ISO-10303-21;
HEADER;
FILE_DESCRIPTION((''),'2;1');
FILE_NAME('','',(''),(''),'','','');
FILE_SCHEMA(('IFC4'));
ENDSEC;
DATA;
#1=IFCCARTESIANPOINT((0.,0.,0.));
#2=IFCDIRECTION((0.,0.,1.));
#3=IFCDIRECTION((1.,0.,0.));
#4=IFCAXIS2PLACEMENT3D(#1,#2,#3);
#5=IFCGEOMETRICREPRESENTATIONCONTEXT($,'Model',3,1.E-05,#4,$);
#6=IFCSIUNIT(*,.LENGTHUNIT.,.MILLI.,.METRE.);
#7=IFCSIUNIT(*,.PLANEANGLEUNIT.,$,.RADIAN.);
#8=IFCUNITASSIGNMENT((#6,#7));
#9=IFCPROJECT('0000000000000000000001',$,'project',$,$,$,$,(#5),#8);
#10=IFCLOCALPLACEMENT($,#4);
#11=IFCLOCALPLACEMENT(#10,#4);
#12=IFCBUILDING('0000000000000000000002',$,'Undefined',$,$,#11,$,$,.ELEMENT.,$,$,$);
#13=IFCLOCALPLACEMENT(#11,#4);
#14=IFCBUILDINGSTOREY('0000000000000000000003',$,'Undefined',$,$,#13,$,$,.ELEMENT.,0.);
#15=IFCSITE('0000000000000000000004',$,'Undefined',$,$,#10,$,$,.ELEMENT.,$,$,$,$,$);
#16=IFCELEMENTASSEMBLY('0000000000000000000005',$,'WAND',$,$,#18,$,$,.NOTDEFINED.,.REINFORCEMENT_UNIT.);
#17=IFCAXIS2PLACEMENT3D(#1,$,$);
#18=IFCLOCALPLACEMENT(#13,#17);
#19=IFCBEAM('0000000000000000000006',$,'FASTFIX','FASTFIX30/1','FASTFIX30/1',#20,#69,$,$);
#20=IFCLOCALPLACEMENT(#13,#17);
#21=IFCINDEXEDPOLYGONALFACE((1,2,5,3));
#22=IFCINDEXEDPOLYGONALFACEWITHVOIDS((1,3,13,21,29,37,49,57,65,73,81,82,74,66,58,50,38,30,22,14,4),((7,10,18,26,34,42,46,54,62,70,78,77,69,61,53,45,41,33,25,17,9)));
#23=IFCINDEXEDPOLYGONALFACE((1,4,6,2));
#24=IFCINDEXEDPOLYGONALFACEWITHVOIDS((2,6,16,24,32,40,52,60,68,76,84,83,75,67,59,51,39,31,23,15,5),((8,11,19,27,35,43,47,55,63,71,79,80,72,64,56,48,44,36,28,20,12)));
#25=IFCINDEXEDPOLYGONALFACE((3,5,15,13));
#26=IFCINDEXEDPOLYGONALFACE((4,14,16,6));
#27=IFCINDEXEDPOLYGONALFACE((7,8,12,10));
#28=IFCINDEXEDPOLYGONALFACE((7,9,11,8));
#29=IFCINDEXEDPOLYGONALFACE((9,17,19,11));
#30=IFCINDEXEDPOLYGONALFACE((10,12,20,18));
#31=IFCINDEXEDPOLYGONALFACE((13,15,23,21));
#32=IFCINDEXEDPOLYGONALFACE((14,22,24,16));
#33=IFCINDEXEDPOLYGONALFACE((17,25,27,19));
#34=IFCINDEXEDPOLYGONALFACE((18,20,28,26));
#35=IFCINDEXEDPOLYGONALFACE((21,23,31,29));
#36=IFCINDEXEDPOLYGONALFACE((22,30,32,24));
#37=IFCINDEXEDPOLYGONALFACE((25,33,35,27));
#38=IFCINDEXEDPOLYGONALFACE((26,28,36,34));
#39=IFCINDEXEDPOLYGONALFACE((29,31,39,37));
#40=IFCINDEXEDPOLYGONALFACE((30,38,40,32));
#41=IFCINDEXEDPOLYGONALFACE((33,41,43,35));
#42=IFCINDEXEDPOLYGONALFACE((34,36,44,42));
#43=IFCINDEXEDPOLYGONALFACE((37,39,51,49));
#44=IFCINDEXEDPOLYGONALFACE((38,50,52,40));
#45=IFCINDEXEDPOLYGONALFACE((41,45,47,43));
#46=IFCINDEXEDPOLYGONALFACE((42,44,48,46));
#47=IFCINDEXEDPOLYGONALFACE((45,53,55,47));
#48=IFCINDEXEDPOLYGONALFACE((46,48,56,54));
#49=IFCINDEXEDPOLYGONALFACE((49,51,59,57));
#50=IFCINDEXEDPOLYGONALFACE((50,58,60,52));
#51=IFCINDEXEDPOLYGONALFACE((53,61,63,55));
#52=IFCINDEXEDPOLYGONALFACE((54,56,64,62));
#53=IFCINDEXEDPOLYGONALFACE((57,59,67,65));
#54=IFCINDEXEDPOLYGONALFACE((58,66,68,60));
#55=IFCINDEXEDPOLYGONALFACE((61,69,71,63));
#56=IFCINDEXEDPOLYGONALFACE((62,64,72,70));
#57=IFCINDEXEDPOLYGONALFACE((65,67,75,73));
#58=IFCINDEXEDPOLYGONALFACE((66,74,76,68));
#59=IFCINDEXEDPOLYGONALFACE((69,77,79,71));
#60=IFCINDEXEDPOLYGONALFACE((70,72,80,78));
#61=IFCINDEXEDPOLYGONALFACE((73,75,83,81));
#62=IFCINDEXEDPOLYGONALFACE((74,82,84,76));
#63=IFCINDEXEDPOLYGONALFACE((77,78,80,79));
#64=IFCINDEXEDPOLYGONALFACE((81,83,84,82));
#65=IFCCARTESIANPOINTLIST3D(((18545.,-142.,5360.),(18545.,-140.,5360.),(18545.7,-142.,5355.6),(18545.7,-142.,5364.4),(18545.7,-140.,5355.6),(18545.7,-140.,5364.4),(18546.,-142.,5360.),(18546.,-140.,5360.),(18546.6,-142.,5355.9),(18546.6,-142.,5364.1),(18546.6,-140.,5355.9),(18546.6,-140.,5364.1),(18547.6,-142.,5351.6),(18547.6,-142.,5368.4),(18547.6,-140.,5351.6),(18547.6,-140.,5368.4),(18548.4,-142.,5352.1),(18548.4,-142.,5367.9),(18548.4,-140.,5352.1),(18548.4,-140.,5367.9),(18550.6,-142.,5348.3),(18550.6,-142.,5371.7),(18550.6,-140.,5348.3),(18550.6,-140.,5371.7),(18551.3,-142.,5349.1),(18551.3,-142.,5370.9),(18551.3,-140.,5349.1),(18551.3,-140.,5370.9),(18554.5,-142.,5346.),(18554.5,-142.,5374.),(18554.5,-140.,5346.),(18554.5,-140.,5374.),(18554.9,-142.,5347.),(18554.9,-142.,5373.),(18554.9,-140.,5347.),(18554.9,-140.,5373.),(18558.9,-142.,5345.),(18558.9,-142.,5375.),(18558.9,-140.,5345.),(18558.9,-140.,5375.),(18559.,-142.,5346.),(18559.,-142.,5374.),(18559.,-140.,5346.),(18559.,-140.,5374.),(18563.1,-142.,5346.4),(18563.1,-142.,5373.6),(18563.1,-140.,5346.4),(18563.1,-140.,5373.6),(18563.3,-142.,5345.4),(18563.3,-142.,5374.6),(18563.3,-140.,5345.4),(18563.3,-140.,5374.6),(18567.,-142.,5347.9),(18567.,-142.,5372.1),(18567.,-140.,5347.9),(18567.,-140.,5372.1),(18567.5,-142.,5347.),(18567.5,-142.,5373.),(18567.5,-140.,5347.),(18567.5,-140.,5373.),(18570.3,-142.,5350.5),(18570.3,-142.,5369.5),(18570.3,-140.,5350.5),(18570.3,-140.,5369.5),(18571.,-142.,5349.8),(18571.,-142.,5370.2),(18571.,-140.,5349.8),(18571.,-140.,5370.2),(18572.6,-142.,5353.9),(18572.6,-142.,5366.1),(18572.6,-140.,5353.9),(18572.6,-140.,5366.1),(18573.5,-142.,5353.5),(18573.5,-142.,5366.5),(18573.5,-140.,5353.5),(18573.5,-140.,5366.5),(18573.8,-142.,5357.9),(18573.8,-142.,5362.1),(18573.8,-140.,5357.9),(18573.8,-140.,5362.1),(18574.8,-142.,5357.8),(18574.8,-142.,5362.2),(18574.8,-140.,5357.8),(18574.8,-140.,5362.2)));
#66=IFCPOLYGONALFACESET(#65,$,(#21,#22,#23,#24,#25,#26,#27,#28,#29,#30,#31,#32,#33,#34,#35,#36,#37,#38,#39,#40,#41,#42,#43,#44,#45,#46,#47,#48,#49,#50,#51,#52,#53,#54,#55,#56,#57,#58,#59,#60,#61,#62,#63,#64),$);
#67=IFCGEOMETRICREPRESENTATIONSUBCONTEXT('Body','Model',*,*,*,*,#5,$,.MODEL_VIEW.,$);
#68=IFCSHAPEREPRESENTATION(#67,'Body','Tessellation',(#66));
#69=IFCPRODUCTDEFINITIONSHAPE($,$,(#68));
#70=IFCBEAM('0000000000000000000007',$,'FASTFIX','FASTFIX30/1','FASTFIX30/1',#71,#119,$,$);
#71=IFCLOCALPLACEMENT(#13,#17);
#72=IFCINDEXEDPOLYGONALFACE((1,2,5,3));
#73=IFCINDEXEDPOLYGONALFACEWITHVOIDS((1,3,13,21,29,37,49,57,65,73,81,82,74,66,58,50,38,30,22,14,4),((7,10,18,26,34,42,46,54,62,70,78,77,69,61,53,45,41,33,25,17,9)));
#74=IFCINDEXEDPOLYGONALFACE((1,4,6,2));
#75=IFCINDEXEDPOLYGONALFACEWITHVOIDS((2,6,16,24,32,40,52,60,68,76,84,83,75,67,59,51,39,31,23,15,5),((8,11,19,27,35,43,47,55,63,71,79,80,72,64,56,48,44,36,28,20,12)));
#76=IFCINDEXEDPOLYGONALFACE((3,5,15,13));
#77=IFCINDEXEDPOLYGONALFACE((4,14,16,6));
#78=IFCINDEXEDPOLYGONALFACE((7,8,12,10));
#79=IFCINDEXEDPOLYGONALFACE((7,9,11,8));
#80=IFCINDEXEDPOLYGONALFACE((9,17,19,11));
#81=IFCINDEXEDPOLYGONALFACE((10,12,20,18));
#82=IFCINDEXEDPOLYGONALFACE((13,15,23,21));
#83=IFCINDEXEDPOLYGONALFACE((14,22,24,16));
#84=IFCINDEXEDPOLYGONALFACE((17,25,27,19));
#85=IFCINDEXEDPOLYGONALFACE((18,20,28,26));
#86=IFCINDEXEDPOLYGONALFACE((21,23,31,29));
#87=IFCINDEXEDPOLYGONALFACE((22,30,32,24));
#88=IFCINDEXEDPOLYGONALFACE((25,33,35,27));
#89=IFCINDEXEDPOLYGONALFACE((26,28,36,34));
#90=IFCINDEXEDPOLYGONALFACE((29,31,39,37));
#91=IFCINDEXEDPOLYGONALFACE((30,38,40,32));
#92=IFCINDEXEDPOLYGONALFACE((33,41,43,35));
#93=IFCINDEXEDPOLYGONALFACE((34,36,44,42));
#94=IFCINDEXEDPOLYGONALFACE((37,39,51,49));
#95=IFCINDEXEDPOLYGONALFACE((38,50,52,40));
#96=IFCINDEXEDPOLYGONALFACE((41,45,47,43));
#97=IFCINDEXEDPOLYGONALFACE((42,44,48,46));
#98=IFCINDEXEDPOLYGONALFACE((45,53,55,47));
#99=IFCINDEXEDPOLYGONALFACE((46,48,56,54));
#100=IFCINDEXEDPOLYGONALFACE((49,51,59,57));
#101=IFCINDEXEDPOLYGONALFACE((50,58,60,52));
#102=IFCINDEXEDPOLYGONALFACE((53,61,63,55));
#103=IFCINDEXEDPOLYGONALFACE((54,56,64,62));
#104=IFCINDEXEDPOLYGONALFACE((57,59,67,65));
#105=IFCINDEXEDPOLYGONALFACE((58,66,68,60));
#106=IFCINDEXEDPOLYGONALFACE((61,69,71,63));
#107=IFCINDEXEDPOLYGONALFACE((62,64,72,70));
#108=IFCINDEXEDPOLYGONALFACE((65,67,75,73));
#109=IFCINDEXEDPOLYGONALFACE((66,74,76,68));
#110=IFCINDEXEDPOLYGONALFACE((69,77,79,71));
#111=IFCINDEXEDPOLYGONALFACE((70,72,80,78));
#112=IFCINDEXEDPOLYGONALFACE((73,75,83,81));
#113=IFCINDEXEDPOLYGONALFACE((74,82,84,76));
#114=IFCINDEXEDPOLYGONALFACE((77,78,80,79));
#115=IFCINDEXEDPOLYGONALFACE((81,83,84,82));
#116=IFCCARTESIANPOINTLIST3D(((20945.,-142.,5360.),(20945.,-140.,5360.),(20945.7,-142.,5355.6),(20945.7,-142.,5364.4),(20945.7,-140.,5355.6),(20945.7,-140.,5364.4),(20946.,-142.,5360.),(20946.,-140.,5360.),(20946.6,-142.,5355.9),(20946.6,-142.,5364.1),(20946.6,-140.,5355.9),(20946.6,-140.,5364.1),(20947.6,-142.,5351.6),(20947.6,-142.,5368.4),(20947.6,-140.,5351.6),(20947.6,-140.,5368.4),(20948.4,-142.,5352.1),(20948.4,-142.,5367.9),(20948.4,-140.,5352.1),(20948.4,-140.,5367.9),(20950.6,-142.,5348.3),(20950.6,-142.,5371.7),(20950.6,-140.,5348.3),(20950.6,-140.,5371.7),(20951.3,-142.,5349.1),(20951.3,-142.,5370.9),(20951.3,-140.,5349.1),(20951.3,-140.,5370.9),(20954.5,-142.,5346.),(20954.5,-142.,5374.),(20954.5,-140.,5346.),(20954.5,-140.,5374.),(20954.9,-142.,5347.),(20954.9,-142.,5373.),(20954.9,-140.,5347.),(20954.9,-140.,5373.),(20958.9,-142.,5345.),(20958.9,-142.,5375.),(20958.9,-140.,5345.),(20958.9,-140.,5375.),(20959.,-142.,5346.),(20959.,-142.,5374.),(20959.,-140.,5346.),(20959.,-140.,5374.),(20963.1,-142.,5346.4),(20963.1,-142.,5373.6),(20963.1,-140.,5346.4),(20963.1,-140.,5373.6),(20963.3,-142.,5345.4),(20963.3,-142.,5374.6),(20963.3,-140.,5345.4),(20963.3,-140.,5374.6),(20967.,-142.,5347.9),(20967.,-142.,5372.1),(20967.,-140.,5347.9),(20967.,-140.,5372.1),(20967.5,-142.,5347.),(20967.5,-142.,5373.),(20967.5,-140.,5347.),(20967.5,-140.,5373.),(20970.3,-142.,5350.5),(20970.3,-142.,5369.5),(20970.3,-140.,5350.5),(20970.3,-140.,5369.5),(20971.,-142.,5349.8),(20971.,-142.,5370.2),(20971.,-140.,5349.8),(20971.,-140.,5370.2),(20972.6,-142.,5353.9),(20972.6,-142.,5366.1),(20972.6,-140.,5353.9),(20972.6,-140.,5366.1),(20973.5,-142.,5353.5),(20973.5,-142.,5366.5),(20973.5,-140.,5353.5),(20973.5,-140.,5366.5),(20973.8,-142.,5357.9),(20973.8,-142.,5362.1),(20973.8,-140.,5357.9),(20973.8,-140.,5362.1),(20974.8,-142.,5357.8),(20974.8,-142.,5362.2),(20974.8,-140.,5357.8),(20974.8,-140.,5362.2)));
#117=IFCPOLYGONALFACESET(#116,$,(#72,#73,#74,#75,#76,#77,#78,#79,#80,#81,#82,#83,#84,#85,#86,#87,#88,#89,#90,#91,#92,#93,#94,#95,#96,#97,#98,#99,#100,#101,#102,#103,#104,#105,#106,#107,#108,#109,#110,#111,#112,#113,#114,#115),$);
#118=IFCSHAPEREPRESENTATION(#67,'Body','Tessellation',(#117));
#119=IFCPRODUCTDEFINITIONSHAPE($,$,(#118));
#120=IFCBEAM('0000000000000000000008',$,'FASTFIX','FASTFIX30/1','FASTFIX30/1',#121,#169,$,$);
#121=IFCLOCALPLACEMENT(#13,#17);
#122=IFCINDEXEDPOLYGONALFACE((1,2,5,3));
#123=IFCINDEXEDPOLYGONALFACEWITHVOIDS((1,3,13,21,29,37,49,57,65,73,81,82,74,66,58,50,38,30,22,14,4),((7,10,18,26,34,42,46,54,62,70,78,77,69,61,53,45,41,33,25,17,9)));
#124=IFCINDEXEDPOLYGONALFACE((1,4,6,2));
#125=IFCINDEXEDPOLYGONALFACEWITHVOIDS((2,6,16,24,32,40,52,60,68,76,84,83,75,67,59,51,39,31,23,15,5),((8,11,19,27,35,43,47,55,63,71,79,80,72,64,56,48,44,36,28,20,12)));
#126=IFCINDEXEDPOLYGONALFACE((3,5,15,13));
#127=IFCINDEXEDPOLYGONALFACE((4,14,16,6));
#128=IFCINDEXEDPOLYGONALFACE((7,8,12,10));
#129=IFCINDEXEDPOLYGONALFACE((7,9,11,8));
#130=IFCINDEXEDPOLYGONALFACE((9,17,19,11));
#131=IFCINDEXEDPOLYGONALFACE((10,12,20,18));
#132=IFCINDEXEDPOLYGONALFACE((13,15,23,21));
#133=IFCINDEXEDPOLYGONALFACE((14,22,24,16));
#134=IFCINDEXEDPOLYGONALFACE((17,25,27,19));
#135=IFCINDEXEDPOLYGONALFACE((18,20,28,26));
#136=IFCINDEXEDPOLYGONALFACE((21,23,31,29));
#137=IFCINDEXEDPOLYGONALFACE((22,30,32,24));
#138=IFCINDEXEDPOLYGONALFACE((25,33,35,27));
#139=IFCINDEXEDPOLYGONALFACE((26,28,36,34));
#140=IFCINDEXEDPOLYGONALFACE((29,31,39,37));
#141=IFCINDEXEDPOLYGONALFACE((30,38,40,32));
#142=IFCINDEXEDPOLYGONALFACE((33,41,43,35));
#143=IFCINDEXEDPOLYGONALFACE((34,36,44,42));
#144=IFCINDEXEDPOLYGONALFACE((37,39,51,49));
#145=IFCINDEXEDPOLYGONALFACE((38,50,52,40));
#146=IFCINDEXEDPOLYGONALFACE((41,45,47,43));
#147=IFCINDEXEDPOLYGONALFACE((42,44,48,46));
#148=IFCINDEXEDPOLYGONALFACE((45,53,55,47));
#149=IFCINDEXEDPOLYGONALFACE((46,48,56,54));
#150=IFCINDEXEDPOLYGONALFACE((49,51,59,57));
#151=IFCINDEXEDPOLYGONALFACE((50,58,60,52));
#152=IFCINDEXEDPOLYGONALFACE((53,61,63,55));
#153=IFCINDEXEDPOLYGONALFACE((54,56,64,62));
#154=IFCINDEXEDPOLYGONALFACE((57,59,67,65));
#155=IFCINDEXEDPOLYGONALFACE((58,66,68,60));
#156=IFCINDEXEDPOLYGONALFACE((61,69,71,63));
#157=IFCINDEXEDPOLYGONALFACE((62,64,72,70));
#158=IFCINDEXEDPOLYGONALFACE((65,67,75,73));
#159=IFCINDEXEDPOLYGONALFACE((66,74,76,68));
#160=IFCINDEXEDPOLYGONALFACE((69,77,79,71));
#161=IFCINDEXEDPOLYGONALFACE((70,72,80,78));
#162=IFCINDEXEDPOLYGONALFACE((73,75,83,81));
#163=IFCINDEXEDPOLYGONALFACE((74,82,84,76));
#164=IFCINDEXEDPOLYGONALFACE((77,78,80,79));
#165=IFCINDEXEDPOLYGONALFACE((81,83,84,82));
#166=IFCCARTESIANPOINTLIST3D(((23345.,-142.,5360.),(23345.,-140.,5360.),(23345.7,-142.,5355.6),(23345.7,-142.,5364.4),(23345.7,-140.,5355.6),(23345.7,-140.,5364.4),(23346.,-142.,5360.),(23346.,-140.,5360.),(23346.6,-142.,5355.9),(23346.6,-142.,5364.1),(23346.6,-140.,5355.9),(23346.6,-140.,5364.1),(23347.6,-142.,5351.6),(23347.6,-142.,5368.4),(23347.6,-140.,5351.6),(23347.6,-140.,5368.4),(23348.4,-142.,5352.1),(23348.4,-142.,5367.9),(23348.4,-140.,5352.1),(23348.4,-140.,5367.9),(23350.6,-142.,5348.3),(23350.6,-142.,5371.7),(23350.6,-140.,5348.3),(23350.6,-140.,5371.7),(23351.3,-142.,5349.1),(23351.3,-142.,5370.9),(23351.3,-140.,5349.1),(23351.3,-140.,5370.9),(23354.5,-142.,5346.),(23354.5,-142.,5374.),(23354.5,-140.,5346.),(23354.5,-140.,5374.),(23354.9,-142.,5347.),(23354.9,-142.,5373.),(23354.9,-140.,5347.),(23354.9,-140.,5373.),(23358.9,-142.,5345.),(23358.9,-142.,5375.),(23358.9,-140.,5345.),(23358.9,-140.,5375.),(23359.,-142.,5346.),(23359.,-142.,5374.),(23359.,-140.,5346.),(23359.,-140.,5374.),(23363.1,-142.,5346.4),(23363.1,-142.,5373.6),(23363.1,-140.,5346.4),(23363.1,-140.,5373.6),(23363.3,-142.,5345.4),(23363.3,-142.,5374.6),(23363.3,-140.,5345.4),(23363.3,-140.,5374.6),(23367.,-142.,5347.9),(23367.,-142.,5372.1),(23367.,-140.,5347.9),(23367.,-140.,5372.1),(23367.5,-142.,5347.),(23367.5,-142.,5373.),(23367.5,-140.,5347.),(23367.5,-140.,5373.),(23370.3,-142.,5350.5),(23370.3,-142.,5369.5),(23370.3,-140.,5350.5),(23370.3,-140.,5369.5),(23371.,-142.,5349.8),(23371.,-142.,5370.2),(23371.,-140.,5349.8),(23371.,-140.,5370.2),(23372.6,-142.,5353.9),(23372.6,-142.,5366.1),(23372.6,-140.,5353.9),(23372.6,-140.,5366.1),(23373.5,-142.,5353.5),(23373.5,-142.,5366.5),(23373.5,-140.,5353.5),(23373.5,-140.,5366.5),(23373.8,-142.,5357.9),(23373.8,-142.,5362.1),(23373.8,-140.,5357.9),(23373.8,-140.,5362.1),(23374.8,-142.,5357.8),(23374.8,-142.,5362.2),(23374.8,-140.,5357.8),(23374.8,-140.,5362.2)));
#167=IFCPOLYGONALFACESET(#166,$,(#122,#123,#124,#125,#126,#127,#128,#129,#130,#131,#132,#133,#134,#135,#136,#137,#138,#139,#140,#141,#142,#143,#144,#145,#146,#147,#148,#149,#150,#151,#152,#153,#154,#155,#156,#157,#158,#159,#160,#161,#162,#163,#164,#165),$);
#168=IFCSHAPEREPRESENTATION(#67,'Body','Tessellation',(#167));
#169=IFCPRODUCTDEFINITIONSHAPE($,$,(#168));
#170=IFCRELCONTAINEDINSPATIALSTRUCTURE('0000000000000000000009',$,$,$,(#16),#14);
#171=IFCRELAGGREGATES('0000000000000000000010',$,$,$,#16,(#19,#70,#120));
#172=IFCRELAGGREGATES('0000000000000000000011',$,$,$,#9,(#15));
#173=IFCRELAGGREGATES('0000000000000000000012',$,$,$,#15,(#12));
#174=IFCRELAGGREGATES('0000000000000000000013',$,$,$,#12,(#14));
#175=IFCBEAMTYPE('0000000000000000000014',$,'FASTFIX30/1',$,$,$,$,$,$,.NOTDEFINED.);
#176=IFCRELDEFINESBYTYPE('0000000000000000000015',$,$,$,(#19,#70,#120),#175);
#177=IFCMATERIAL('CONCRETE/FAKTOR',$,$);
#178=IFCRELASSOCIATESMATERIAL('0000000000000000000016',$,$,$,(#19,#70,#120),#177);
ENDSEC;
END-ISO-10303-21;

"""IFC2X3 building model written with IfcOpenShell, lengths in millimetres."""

from ifc_helpers import new_model, si_unit, frame, frame_2d, origin_with_axes, place, context, subcontext, project, spatial, hollow_circle, extrude, material, type_object, element, aggregate, save


model = new_model("IFC2X3")

# Units and contexts
model_context = context("Model", 3, precision=1e-05, world=origin_with_axes())
body_context = subcontext(model_context, "Body", "Model", "MODEL_VIEW")
ifc_project = project(units=[si_unit("LENGTHUNIT", "METRE", prefix="MILLI"), si_unit("PLANEANGLEUNIT", "RADIAN")], contexts=[model_context])

# Site, building, storey
site_placement = place(None, origin_with_axes())
site = spatial("IfcSite", under=ifc_project, at=site_placement, Name="Undefined", CompositionType="ELEMENT")
building_placement = place(site_placement, origin_with_axes())
building = spatial("IfcBuilding", under=site, at=building_placement, Name="Undefined", CompositionType="ELEMENT")
storey_placement = place(building_placement, origin_with_axes())
storey = spatial("IfcBuildingStorey", under=building, at=storey_placement, Name="Undefined", CompositionType="ELEMENT", Elevation=0.0)

# Shared definitions
ifc_material_1 = material(Name="CONCRETE/FAKTOR")

# Element assembly
assembly_1_placement = place(storey_placement, origin_with_axes())
assembly_1 = element("IfcElementAssembly", 1, at=assembly_1_placement, inside=storey, Name="WAND", AssemblyPlace="NOTDEFINED", PredefinedType="REINFORCEMENT_UNIT")

# Beams
beam_type_1 = type_object("IfcBeamType", Name="FASTFIX30/1", PredefinedType="NOTDEFINED")
beam_1_placement = place(assembly_1_placement, frame((18560.0, -140.0, 5360.0), z_axis=(0.0, 0.0, 1.0), x_axis=(0.0, -1.0, 0.0)))
beam_1 = element("IfcBeam", 2, at=beam_1_placement, type_object=beam_type_1, material=ifc_material_1, Name="FASTFIX", Description="FASTFIX30/1", ObjectType="FASTFIX30/1", context=body_context, shape_type="SweptSolid", body=[
    extrude(hollow_circle(Radius=15.0, WallThickness=1.0, at=frame_2d((0.0, 0.0), x_axis=(1.0, 0.0))), frame((2.0, 0.0, 0.0), z_axis=(-1.0, 0.0, 0.0), x_axis=(0.0, -1.0, 0.0)), (0.0, 0.0, 1.0), 2.0),
])
beam_2_placement = place(assembly_1_placement, frame((20960.0, -140.0, 5360.0), z_axis=(0.0, 0.0, 1.0), x_axis=(0.0, -1.0, 0.0)))
beam_2 = element("IfcBeam", 3, at=beam_2_placement, type_object=beam_type_1, material=ifc_material_1, Name="FASTFIX", Description="FASTFIX30/1", ObjectType="FASTFIX30/1", context=body_context, shape_type="SweptSolid", body=[
    extrude(hollow_circle(Radius=15.0, WallThickness=1.0, at=frame_2d((0.0, 0.0), x_axis=(1.0, 0.0))), frame((2.0, 0.0, 0.0), z_axis=(-1.0, 0.0, 0.0), x_axis=(0.0, -1.0, 0.0)), (0.0, 0.0, 1.0), 2.0),
])
beam_3_placement = place(assembly_1_placement, frame((23360.0, -140.0, 5360.0), z_axis=(0.0, 0.0, 1.0), x_axis=(0.0, -1.0, 0.0)))
beam_3 = element("IfcBeam", 4, at=beam_3_placement, type_object=beam_type_1, material=ifc_material_1, Name="FASTFIX", Description="FASTFIX30/1", ObjectType="FASTFIX30/1", context=body_context, shape_type="SweptSolid", body=[
    extrude(hollow_circle(Radius=15.0, WallThickness=1.0, at=frame_2d((0.0, 0.0), x_axis=(1.0, 0.0))), frame((2.0, 0.0, 0.0), z_axis=(-1.0, 0.0, 0.0), x_axis=(0.0, -1.0, 0.0)), (0.0, 0.0, 1.0), 2.0),
])
aggregate(assembly_1, [beam_1, beam_2, beam_3])

save(model, "model.ifc")
